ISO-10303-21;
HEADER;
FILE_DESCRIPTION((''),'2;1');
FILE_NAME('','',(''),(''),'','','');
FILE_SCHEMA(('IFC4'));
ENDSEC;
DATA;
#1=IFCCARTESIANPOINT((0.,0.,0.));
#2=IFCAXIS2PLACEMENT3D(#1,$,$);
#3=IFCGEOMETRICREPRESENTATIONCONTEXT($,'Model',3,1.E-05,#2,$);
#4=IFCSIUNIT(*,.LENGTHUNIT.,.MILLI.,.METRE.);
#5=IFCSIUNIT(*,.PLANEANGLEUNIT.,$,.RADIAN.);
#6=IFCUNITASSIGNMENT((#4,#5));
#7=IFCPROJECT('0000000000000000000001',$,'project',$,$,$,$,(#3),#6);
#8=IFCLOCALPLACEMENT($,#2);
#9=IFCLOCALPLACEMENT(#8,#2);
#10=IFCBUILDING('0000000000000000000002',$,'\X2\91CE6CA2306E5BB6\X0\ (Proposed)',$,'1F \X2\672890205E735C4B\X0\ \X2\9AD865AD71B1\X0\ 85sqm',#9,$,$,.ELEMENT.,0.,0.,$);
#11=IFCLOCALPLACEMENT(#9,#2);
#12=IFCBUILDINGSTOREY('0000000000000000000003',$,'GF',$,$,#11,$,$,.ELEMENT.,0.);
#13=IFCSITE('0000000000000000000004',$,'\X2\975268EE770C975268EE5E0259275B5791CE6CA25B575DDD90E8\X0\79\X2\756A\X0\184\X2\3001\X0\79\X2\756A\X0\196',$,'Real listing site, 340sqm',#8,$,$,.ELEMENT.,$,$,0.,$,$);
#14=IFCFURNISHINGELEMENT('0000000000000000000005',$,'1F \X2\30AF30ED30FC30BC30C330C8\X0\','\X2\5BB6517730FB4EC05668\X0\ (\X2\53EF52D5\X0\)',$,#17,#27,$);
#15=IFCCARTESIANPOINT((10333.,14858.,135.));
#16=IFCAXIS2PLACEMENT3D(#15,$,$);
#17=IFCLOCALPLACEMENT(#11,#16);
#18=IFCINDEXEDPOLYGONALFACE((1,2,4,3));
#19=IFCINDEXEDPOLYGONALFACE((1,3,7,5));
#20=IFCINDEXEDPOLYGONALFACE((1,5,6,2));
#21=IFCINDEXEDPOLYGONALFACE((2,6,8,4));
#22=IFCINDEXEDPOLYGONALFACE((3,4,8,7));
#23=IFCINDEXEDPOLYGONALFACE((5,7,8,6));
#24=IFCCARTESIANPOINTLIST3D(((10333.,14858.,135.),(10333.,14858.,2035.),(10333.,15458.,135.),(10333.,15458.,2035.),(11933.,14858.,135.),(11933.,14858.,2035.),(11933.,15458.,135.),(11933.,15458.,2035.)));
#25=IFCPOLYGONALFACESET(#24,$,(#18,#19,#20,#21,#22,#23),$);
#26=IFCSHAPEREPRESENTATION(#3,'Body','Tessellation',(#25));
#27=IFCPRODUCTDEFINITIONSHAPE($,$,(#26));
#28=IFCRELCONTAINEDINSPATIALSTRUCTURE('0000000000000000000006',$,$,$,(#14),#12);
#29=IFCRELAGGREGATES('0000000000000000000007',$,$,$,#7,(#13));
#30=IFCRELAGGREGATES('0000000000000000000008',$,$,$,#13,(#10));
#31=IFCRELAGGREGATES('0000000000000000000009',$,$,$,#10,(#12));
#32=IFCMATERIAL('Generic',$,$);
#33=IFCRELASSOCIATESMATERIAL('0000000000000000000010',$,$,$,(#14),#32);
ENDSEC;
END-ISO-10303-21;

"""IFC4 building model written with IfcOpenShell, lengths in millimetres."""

from ifc_helpers import new_model, si_unit, frame, frame_2d, origin, place, context, project, spatial, rectangle, extrude, material, element, save


model = new_model("IFC4")

# Units and contexts
model_context = context("Model", 3, precision=1e-05, world=origin())
ifc_project = project(units=[si_unit("LENGTHUNIT", "METRE", prefix="MILLI"), si_unit("PLANEANGLEUNIT", "RADIAN")], contexts=[model_context])

# Site, building, storey
site_placement = place(None, origin())
site = spatial("IfcSite", under=ifc_project, at=site_placement, Name="青森県青森市大字野沢字川部79番184、79番196", ObjectType="Real listing site, 340sqm", CompositionType="ELEMENT", RefElevation=0.0)
building_placement = place(site_placement, origin())
building = spatial("IfcBuilding", under=site, at=building_placement, Name="野沢の家 (Proposed)", ObjectType="1F 木造平屋 高断熱 85sqm", CompositionType="ELEMENT", ElevationOfRefHeight=0.0, ElevationOfTerrain=0.0)
storey_placement = place(building_placement, origin())
storey = spatial("IfcBuildingStorey", under=building, at=storey_placement, Name="GF", CompositionType="ELEMENT", Elevation=0.0)

# Shared definitions
ifc_material_1 = material(Name="Generic")

# Furnishing element
furnishing_placement = place(storey_placement, frame((10333.0, 14858.0, 135.0)))
element("IfcFurnishingElement", 1, at=furnishing_placement, inside=storey, material=ifc_material_1, Name="1F クローゼット", Description="家具・什器 (可動)", context=model_context, shape_type="SweptSolid", body=[
    extrude(rectangle(XDim=1600.0, YDim=600.0, at=frame_2d((800.0, 300.0))), frame((10333.0, 14858.0, 135.0)), (0.0, 0.0, 1.0), 1900.0),
])

save(model, "model.ifc")
